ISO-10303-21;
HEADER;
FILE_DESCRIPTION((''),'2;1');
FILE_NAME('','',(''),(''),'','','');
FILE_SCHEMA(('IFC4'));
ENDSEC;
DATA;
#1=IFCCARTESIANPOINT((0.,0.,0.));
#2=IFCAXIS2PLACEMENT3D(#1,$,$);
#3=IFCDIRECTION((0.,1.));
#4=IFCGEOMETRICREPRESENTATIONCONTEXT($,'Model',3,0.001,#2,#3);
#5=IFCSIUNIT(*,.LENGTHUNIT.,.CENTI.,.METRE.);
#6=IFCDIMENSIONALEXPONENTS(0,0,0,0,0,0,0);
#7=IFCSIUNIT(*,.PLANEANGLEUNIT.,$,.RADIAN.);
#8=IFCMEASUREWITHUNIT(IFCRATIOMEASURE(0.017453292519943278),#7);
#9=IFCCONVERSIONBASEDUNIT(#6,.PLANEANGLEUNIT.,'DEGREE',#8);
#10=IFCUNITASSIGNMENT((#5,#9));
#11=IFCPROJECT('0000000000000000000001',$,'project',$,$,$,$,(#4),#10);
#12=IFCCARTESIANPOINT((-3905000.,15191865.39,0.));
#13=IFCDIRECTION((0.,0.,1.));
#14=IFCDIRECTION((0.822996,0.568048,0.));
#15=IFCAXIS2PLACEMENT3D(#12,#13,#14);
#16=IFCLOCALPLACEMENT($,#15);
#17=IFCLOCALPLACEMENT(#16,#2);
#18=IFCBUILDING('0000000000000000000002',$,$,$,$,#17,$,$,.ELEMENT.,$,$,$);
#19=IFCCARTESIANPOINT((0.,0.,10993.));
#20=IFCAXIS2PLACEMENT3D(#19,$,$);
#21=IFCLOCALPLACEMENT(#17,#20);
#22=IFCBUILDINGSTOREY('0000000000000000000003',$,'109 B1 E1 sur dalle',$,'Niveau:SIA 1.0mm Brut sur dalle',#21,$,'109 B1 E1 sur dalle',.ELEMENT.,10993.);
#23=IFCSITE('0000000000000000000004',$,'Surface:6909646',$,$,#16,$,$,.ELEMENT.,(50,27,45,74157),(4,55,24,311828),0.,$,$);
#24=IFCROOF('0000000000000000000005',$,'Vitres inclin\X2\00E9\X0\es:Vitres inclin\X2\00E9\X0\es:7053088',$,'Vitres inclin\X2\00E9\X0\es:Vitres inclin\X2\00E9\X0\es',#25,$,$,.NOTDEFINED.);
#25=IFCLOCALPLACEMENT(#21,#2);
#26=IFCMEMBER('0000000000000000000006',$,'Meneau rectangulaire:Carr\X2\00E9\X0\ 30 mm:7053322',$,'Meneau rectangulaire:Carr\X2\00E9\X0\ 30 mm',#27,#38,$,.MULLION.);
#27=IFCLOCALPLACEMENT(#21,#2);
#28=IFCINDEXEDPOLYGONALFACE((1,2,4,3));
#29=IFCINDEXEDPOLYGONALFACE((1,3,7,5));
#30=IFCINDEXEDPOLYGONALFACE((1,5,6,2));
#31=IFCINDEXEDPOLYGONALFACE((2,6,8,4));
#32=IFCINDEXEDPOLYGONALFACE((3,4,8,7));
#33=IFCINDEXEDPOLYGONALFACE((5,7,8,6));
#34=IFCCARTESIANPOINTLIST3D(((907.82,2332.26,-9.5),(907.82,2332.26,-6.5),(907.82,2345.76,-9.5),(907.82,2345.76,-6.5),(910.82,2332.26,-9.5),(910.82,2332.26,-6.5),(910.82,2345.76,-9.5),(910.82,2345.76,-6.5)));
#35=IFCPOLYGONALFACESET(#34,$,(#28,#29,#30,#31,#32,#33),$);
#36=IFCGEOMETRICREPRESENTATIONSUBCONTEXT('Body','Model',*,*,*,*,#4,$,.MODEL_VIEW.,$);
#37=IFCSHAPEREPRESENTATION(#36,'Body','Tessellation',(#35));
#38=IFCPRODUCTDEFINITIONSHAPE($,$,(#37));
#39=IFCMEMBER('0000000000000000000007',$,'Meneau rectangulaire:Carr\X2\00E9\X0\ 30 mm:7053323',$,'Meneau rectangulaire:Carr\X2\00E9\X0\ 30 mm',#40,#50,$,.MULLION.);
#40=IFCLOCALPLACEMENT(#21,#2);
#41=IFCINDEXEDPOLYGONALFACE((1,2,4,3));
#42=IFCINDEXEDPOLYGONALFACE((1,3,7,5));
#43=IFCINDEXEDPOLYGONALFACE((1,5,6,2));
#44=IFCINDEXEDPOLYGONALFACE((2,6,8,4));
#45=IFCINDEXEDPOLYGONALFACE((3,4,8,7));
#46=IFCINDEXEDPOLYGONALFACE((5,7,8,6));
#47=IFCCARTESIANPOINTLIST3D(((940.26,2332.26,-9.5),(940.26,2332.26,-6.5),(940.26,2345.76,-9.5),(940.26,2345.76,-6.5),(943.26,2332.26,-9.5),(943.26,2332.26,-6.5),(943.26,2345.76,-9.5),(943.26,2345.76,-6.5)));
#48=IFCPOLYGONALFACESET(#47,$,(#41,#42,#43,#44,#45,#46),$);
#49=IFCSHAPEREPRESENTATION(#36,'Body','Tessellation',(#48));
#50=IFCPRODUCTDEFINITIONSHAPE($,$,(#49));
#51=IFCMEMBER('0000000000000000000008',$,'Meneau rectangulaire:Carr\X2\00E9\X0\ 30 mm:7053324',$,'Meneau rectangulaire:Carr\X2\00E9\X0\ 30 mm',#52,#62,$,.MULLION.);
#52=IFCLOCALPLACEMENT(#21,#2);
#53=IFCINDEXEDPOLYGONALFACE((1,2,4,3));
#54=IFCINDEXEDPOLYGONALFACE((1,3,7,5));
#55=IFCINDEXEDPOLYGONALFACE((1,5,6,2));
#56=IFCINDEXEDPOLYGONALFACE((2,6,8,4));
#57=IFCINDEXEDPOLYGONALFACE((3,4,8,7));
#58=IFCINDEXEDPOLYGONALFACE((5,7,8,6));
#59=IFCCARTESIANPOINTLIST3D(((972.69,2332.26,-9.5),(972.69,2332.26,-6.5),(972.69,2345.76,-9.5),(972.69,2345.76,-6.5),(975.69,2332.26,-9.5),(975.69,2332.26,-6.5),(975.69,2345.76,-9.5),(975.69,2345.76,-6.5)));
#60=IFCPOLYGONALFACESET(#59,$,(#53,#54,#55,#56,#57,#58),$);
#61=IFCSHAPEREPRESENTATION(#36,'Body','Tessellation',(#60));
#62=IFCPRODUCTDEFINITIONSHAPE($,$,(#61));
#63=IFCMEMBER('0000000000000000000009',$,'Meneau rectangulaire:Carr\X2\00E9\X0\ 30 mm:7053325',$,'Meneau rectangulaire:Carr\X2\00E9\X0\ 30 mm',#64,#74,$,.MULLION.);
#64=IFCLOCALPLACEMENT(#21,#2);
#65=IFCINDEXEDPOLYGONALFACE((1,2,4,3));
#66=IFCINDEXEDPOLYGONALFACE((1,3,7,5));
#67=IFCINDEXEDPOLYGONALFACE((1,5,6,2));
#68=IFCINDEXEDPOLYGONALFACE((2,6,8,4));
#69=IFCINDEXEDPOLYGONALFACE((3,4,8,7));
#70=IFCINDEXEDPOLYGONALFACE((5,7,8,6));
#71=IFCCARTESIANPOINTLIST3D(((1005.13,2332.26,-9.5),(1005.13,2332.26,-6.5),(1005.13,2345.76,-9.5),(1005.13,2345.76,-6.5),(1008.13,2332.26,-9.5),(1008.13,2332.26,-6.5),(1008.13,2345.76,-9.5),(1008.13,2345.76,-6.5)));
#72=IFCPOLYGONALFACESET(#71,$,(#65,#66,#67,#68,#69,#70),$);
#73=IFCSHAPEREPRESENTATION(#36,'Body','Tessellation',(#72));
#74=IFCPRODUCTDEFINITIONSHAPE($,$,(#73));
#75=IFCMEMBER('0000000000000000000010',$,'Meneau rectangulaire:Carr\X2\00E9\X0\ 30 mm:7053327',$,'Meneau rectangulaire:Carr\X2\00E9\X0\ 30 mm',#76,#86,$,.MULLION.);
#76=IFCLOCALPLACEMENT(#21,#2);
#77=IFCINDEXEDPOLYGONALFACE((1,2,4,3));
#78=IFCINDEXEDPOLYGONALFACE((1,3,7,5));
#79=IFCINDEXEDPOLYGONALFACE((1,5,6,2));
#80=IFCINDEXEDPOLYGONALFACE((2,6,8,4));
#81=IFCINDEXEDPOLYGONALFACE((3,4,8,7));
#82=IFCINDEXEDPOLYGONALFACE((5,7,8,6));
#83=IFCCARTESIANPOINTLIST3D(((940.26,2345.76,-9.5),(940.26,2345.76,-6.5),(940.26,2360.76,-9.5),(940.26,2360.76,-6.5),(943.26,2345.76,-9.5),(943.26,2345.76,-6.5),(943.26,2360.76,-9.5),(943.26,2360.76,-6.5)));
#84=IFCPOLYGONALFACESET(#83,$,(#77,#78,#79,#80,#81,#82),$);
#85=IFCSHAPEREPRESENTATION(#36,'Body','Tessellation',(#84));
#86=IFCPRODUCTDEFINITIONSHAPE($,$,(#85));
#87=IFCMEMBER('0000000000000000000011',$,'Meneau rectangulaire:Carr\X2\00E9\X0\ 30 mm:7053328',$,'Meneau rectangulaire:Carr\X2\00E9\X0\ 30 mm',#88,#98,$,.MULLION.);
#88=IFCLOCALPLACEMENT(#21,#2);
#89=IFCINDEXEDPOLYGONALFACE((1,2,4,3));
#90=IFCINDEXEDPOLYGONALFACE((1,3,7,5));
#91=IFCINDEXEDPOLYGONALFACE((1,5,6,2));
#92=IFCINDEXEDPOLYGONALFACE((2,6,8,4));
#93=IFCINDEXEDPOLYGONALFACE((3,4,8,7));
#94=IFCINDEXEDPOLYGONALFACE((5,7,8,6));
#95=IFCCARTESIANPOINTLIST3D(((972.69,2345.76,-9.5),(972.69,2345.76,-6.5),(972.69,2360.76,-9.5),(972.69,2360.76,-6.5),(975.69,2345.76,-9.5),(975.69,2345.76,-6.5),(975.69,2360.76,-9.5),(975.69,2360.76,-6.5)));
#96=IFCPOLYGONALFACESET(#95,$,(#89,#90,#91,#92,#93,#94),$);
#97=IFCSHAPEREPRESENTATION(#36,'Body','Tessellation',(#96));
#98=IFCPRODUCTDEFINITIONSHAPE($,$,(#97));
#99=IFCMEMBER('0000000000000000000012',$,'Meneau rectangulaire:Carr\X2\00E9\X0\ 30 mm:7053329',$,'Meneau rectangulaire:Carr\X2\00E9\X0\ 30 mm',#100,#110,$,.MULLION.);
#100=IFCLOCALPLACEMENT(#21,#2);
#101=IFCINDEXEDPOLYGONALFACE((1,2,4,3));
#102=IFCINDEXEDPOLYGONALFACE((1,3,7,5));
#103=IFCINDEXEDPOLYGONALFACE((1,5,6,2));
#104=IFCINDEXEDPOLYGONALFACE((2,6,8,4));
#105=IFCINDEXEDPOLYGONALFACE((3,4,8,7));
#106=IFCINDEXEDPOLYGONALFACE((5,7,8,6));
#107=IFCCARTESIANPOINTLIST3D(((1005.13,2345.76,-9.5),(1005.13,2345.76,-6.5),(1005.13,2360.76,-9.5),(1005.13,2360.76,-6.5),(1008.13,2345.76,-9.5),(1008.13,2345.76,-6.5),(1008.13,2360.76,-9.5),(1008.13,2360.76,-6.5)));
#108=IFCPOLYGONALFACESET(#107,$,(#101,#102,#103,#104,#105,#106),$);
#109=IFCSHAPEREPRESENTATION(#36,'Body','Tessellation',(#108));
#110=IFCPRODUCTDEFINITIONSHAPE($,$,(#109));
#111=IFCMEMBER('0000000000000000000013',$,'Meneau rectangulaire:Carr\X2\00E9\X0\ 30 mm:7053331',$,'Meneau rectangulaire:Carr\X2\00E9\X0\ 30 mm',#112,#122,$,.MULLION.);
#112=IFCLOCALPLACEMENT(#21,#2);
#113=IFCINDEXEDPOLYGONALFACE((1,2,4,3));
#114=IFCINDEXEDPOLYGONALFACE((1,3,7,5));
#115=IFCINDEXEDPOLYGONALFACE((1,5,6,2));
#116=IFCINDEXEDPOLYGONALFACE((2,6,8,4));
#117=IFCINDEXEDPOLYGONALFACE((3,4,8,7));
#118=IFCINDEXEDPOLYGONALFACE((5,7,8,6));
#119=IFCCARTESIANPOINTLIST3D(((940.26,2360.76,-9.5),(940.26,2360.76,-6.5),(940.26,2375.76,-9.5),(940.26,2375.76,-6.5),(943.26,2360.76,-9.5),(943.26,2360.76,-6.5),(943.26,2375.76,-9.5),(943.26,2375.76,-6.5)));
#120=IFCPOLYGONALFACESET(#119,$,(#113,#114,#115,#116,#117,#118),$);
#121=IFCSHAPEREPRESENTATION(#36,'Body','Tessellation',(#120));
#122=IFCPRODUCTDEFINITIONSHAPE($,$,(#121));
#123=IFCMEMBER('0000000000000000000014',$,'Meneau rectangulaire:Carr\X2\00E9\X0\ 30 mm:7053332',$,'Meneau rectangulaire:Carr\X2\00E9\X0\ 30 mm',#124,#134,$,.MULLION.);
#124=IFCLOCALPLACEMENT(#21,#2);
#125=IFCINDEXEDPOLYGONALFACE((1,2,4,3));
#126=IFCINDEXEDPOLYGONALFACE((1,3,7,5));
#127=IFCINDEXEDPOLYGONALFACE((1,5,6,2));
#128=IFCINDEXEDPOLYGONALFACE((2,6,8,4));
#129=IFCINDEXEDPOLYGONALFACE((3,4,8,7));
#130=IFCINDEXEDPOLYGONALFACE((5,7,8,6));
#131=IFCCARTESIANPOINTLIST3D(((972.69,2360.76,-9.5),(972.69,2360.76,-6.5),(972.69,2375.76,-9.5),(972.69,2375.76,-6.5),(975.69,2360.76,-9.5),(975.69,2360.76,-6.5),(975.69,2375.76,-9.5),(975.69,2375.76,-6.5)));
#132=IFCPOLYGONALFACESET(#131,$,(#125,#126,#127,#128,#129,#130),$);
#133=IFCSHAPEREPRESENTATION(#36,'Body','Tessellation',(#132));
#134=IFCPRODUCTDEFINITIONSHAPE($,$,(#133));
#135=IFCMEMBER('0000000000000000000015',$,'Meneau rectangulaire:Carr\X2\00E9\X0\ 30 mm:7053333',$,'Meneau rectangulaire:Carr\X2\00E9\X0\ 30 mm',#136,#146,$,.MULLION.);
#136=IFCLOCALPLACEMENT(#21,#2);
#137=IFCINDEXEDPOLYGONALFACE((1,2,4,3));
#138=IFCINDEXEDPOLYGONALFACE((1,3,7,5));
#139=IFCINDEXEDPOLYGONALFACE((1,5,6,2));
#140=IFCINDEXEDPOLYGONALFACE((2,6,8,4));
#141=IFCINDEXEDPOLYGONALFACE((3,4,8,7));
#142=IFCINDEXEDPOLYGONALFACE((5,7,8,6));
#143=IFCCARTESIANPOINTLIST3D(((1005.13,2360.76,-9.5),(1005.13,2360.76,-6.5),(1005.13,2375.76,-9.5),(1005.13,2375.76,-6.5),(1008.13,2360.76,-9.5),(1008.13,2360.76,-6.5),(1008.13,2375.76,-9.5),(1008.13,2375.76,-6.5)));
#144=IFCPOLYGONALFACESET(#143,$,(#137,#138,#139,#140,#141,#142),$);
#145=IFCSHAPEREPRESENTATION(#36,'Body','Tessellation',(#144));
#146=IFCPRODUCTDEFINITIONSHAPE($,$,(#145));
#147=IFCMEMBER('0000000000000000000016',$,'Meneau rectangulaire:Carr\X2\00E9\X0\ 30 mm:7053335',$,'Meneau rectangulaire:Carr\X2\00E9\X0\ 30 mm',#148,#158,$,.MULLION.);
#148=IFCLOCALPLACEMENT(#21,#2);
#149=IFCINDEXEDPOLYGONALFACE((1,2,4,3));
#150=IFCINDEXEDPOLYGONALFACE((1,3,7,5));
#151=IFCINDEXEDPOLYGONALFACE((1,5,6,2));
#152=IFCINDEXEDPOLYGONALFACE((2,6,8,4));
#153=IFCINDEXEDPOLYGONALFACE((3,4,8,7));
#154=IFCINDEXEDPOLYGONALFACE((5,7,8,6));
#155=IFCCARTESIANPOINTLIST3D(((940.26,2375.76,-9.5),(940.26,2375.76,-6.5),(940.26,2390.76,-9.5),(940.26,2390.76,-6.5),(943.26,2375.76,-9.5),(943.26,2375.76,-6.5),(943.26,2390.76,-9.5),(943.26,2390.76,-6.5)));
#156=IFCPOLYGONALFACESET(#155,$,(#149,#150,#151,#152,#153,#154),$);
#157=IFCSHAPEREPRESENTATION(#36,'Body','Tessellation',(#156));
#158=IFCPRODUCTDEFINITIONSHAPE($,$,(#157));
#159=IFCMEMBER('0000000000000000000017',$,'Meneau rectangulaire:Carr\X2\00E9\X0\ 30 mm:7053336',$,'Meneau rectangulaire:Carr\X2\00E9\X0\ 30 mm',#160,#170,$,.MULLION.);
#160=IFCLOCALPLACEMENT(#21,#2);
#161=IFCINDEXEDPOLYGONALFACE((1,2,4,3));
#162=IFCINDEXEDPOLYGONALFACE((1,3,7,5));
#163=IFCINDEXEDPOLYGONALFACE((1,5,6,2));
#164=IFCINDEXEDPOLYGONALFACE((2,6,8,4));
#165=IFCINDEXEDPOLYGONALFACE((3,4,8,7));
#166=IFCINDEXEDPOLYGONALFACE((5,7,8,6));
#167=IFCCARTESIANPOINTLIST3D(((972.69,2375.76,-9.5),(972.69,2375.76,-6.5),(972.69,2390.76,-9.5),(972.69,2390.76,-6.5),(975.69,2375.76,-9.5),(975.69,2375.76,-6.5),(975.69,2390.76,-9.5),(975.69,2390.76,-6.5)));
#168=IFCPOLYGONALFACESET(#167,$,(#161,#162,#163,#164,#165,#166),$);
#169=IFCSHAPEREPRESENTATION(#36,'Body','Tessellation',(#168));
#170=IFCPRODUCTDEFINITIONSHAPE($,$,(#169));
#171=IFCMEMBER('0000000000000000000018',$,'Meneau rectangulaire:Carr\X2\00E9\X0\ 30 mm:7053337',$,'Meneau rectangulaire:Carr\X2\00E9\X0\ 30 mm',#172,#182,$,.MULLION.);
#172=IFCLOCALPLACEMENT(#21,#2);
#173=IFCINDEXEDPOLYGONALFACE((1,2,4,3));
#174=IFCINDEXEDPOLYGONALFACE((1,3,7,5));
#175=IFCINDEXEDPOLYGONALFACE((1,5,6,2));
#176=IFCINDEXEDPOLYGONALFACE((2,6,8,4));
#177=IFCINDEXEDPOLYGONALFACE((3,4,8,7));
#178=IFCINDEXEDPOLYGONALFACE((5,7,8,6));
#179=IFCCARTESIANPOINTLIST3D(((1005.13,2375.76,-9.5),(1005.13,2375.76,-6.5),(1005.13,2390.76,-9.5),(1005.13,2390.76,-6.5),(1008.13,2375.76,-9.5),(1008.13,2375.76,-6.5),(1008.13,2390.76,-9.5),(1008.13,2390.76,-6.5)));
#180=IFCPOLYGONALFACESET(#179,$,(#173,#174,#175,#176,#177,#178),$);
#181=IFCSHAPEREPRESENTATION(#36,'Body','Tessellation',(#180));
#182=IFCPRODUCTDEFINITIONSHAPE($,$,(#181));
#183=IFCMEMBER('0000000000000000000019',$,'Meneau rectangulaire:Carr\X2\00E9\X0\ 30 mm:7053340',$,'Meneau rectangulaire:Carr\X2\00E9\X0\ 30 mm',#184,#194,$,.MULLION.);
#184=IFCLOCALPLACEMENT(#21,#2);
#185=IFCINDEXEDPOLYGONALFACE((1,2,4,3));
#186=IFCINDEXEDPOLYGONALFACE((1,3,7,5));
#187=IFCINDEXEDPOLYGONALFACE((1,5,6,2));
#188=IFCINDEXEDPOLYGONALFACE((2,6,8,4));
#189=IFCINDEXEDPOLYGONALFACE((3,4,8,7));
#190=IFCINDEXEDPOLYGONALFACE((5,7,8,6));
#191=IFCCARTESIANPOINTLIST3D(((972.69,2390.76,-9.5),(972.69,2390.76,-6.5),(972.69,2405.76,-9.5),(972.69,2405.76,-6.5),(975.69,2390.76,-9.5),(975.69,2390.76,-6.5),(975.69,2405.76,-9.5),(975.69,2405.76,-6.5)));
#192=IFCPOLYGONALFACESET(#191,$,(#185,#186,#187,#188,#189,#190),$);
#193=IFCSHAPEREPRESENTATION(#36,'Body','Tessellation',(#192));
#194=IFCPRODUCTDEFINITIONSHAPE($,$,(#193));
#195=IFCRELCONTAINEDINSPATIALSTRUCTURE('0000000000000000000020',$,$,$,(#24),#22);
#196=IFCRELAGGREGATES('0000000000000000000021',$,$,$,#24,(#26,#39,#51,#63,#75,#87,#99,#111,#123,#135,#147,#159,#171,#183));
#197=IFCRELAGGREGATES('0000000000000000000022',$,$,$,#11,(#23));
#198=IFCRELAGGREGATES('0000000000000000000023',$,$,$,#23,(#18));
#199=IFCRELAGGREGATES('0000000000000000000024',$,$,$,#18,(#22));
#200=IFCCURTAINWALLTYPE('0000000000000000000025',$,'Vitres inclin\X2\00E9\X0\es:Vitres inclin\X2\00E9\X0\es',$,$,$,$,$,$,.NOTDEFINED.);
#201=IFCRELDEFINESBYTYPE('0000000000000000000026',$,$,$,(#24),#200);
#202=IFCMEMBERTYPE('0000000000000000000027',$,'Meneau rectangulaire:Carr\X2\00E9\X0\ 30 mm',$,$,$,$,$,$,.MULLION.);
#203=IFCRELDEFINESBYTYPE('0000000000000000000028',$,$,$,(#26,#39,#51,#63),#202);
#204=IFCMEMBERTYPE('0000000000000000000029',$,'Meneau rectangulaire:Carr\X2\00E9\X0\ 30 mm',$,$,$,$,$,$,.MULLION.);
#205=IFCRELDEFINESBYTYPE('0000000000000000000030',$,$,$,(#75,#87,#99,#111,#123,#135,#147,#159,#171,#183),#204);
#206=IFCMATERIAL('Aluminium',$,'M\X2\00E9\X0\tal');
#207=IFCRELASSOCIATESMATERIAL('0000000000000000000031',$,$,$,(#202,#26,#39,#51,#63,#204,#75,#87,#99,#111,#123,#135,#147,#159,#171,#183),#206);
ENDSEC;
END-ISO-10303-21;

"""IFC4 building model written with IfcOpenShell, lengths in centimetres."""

from ifc_helpers import new_model, entity, si_unit, converted_unit, direction, frame, origin, place, context, subcontext, project, spatial, indexed_curve, outline, extrude, source, transform, mapped, material, type_object, type_shapes, element, aggregate, save


model = new_model("IFC4")

# Units and contexts
model_context = context("Model", 3, precision=0.001, world=origin(), true_north=direction((0.0, 1.0)))
body_context = subcontext(model_context, "Body", "Model", "MODEL_VIEW")
ifc_project = project(units=[si_unit("LENGTHUNIT", "METRE", prefix="CENTI"), converted_unit("PLANEANGLEUNIT", "DEGREE", entity("IfcRatioMeasure", 0.017453292519943278), si_unit("PLANEANGLEUNIT", "RADIAN"), dimensions=[0, 0, 0, 0, 0, 0, 0])], contexts=[model_context])

# Site, building, storey
site_placement = place(None, frame((-3905000.0, 15191865.39, 0.0), z_axis=(0.0, 0.0, 1.0), x_axis=(0.822996, 0.568048, 0.0)))
site = spatial("IfcSite", under=ifc_project, at=site_placement, Name="Surface:6909646", CompositionType="ELEMENT", RefLatitude=(50, 27, 45, 74157), RefLongitude=(4, 55, 24, 311828), RefElevation=0.0)
building_placement = place(site_placement, origin())
building = spatial("IfcBuilding", under=site, at=building_placement, CompositionType="ELEMENT")
storey_placement = place(building_placement, frame((0.0, 0.0, 10993.0)))
storey = spatial("IfcBuildingStorey", under=building, at=storey_placement, Name="109 B1 E1 sur dalle", ObjectType="Niveau:SIA 1.0mm Brut sur dalle", LongName="109 B1 E1 sur dalle", CompositionType="ELEMENT", Elevation=10993.0)

# Roof, members
curtain_wall_type = type_object("IfcCurtainWallType", Name="Vitres inclinées:Vitres inclinées", PredefinedType="NOTDEFINED")
roof_placement = place(storey_placement, frame((0.0, 0.0, -10993.0)))
roof = element("IfcRoof", 1, at=roof_placement, inside=storey, type_object=curtain_wall_type, Name="Vitres inclinées:Vitres inclinées:7053088", ObjectType="Vitres inclinées:Vitres inclinées", PredefinedType="NOTDEFINED")
ifc_material = material(Name="Aluminium", Category="Métal")
member_type_1 = type_object("IfcMemberType", Name="Meneau rectangulaire:Carré 30 mm", PredefinedType="MULLION", material=ifc_material)
shared_shape_1 = source(origin(), body_context, "Body", "SweptSolid", [
    extrude(outline(indexed_curve([(-1.5, -1.5), (1.5, -1.5), (1.5, 1.5), (-1.5, 1.5), (-1.5, -1.5)], self_intersect=False)), frame((0.0, 0.0, -13.5), z_axis=(0.0, 0.0, 1.0), x_axis=(0.0, -1.0, 0.0)), (0.0, 0.0, 1.0), 13.5),
])
type_shapes(member_type_1, [shared_shape_1])
member_1_placement = place(roof_placement, frame((909.32, 2345.76, 10985.0), z_axis=(0.0, 1.0, 0.0), x_axis=(1.0, 0.0, 0.0)))
member_1 = element("IfcMember", 2, at=member_1_placement, type_object=member_type_1, material=ifc_material, Name="Meneau rectangulaire:Carré 30 mm:7053322", ObjectType="Meneau rectangulaire:Carré 30 mm", PredefinedType="MULLION", context=body_context, shape_type="MappedRepresentation", body=[
    mapped(shared_shape_1, transform((0.0, 0.0, 0.0), scale=1.0)),
])
member_2_placement = place(roof_placement, frame((941.76, 2345.76, 10985.0), z_axis=(0.0, 1.0, 0.0), x_axis=(1.0, 0.0, 0.0)))
member_2 = element("IfcMember", 3, at=member_2_placement, type_object=member_type_1, material=ifc_material, Name="Meneau rectangulaire:Carré 30 mm:7053323", ObjectType="Meneau rectangulaire:Carré 30 mm", PredefinedType="MULLION", context=body_context, shape_type="MappedRepresentation", body=[
    mapped(shared_shape_1, transform((0.0, 0.0, 0.0), scale=1.0)),
])
member_3_placement = place(roof_placement, frame((974.19, 2345.76, 10985.0), z_axis=(0.0, 1.0, 0.0), x_axis=(1.0, 0.0, 0.0)))
member_3 = element("IfcMember", 4, at=member_3_placement, type_object=member_type_1, material=ifc_material, Name="Meneau rectangulaire:Carré 30 mm:7053324", ObjectType="Meneau rectangulaire:Carré 30 mm", PredefinedType="MULLION", context=body_context, shape_type="MappedRepresentation", body=[
    mapped(shared_shape_1, transform((0.0, 0.0, 0.0), scale=1.0)),
])
member_4_placement = place(roof_placement, frame((1006.63, 2345.76, 10985.0), z_axis=(0.0, 1.0, 0.0), x_axis=(1.0, 0.0, 0.0)))
member_4 = element("IfcMember", 5, at=member_4_placement, type_object=member_type_1, material=ifc_material, Name="Meneau rectangulaire:Carré 30 mm:7053325", ObjectType="Meneau rectangulaire:Carré 30 mm", PredefinedType="MULLION", context=body_context, shape_type="MappedRepresentation", body=[
    mapped(shared_shape_1, transform((0.0, 0.0, 0.0), scale=1.0)),
])
member_type_2 = type_object("IfcMemberType", Name="Meneau rectangulaire:Carré 30 mm", PredefinedType="MULLION", material=ifc_material)
shared_shape_2 = source(origin(), body_context, "Body", "SweptSolid", [
    extrude(outline(indexed_curve([(-1.5, -1.5), (1.5, -1.5), (1.5, 1.5), (-1.5, 1.5), (-1.5, -1.5)], self_intersect=False)), frame((0.0, 0.0, -15.0), z_axis=(0.0, 0.0, 1.0), x_axis=(0.0, -1.0, 0.0)), (0.0, 0.0, 1.0), 15.0),
])
type_shapes(member_type_2, [shared_shape_2])
member_5_placement = place(roof_placement, frame((941.76, 2360.76, 10985.0), z_axis=(0.0, 1.0, 0.0), x_axis=(1.0, 0.0, 0.0)))
member_5 = element("IfcMember", 6, at=member_5_placement, type_object=member_type_2, material=ifc_material, Name="Meneau rectangulaire:Carré 30 mm:7053327", ObjectType="Meneau rectangulaire:Carré 30 mm", PredefinedType="MULLION", context=body_context, shape_type="MappedRepresentation", body=[
    mapped(shared_shape_2, transform((0.0, 0.0, 0.0), scale=1.0)),
])
member_6_placement = place(roof_placement, frame((974.19, 2360.76, 10985.0), z_axis=(0.0, 1.0, 0.0), x_axis=(1.0, 0.0, 0.0)))
member_6 = element("IfcMember", 7, at=member_6_placement, type_object=member_type_2, material=ifc_material, Name="Meneau rectangulaire:Carré 30 mm:7053328", ObjectType="Meneau rectangulaire:Carré 30 mm", PredefinedType="MULLION", context=body_context, shape_type="MappedRepresentation", body=[
    mapped(shared_shape_2, transform((0.0, 0.0, 0.0), scale=1.0)),
])
member_7_placement = place(roof_placement, frame((1006.63, 2360.76, 10985.0), z_axis=(0.0, 1.0, 0.0), x_axis=(1.0, 0.0, 0.0)))
member_7 = element("IfcMember", 8, at=member_7_placement, type_object=member_type_2, material=ifc_material, Name="Meneau rectangulaire:Carré 30 mm:7053329", ObjectType="Meneau rectangulaire:Carré 30 mm", PredefinedType="MULLION", context=body_context, shape_type="MappedRepresentation", body=[
    mapped(shared_shape_2, transform((0.0, 0.0, 0.0), scale=1.0)),
])
member_8_placement = place(roof_placement, frame((941.76, 2375.76, 10985.0), z_axis=(0.0, 1.0, 0.0), x_axis=(1.0, 0.0, 0.0)))
member_8 = element("IfcMember", 9, at=member_8_placement, type_object=member_type_2, material=ifc_material, Name="Meneau rectangulaire:Carré 30 mm:7053331", ObjectType="Meneau rectangulaire:Carré 30 mm", PredefinedType="MULLION", context=body_context, shape_type="MappedRepresentation", body=[
    mapped(shared_shape_2, transform((0.0, 0.0, 0.0), scale=1.0)),
])
member_9_placement = place(roof_placement, frame((974.19, 2375.76, 10985.0), z_axis=(0.0, 1.0, 0.0), x_axis=(1.0, 0.0, 0.0)))
member_9 = element("IfcMember", 10, at=member_9_placement, type_object=member_type_2, material=ifc_material, Name="Meneau rectangulaire:Carré 30 mm:7053332", ObjectType="Meneau rectangulaire:Carré 30 mm", PredefinedType="MULLION", context=body_context, shape_type="MappedRepresentation", body=[
    mapped(shared_shape_2, transform((0.0, 0.0, 0.0), scale=1.0)),
])
member_10_placement = place(roof_placement, frame((1006.63, 2375.76, 10985.0), z_axis=(0.0, 1.0, 0.0), x_axis=(1.0, 0.0, 0.0)))
member_10 = element("IfcMember", 11, at=member_10_placement, type_object=member_type_2, material=ifc_material, Name="Meneau rectangulaire:Carré 30 mm:7053333", ObjectType="Meneau rectangulaire:Carré 30 mm", PredefinedType="MULLION", context=body_context, shape_type="MappedRepresentation", body=[
    mapped(shared_shape_2, transform((0.0, 0.0, 0.0), scale=1.0)),
])
member_11_placement = place(roof_placement, frame((941.76, 2390.76, 10985.0), z_axis=(0.0, 1.0, 0.0), x_axis=(1.0, 0.0, 0.0)))
member_11 = element("IfcMember", 12, at=member_11_placement, type_object=member_type_2, material=ifc_material, Name="Meneau rectangulaire:Carré 30 mm:7053335", ObjectType="Meneau rectangulaire:Carré 30 mm", PredefinedType="MULLION", context=body_context, shape_type="MappedRepresentation", body=[
    mapped(shared_shape_2, transform((0.0, 0.0, 0.0), scale=1.0)),
])
member_12_placement = place(roof_placement, frame((974.19, 2390.76, 10985.0), z_axis=(0.0, 1.0, 0.0), x_axis=(1.0, 0.0, 0.0)))
member_12 = element("IfcMember", 13, at=member_12_placement, type_object=member_type_2, material=ifc_material, Name="Meneau rectangulaire:Carré 30 mm:7053336", ObjectType="Meneau rectangulaire:Carré 30 mm", PredefinedType="MULLION", context=body_context, shape_type="MappedRepresentation", body=[
    mapped(shared_shape_2, transform((0.0, 0.0, 0.0), scale=1.0)),
])
member_13_placement = place(roof_placement, frame((1006.63, 2390.76, 10985.0), z_axis=(0.0, 1.0, 0.0), x_axis=(1.0, 0.0, 0.0)))
member_13 = element("IfcMember", 14, at=member_13_placement, type_object=member_type_2, material=ifc_material, Name="Meneau rectangulaire:Carré 30 mm:7053337", ObjectType="Meneau rectangulaire:Carré 30 mm", PredefinedType="MULLION", context=body_context, shape_type="MappedRepresentation", body=[
    mapped(shared_shape_2, transform((0.0, 0.0, 0.0), scale=1.0)),
])
member_14_placement = place(roof_placement, frame((974.19, 2405.76, 10985.0), z_axis=(0.0, 1.0, 0.0), x_axis=(1.0, 0.0, 0.0)))
member_14 = element("IfcMember", 15, at=member_14_placement, type_object=member_type_2, material=ifc_material, Name="Meneau rectangulaire:Carré 30 mm:7053340", ObjectType="Meneau rectangulaire:Carré 30 mm", PredefinedType="MULLION", context=body_context, shape_type="MappedRepresentation", body=[
    mapped(shared_shape_2, transform((0.0, 0.0, 0.0), scale=1.0)),
])
aggregate(roof, [member_1, member_2, member_3, member_4, member_5, member_6, member_7, member_8, member_9, member_10, member_11, member_12, member_13, member_14])

save(model, "model.ifc")
